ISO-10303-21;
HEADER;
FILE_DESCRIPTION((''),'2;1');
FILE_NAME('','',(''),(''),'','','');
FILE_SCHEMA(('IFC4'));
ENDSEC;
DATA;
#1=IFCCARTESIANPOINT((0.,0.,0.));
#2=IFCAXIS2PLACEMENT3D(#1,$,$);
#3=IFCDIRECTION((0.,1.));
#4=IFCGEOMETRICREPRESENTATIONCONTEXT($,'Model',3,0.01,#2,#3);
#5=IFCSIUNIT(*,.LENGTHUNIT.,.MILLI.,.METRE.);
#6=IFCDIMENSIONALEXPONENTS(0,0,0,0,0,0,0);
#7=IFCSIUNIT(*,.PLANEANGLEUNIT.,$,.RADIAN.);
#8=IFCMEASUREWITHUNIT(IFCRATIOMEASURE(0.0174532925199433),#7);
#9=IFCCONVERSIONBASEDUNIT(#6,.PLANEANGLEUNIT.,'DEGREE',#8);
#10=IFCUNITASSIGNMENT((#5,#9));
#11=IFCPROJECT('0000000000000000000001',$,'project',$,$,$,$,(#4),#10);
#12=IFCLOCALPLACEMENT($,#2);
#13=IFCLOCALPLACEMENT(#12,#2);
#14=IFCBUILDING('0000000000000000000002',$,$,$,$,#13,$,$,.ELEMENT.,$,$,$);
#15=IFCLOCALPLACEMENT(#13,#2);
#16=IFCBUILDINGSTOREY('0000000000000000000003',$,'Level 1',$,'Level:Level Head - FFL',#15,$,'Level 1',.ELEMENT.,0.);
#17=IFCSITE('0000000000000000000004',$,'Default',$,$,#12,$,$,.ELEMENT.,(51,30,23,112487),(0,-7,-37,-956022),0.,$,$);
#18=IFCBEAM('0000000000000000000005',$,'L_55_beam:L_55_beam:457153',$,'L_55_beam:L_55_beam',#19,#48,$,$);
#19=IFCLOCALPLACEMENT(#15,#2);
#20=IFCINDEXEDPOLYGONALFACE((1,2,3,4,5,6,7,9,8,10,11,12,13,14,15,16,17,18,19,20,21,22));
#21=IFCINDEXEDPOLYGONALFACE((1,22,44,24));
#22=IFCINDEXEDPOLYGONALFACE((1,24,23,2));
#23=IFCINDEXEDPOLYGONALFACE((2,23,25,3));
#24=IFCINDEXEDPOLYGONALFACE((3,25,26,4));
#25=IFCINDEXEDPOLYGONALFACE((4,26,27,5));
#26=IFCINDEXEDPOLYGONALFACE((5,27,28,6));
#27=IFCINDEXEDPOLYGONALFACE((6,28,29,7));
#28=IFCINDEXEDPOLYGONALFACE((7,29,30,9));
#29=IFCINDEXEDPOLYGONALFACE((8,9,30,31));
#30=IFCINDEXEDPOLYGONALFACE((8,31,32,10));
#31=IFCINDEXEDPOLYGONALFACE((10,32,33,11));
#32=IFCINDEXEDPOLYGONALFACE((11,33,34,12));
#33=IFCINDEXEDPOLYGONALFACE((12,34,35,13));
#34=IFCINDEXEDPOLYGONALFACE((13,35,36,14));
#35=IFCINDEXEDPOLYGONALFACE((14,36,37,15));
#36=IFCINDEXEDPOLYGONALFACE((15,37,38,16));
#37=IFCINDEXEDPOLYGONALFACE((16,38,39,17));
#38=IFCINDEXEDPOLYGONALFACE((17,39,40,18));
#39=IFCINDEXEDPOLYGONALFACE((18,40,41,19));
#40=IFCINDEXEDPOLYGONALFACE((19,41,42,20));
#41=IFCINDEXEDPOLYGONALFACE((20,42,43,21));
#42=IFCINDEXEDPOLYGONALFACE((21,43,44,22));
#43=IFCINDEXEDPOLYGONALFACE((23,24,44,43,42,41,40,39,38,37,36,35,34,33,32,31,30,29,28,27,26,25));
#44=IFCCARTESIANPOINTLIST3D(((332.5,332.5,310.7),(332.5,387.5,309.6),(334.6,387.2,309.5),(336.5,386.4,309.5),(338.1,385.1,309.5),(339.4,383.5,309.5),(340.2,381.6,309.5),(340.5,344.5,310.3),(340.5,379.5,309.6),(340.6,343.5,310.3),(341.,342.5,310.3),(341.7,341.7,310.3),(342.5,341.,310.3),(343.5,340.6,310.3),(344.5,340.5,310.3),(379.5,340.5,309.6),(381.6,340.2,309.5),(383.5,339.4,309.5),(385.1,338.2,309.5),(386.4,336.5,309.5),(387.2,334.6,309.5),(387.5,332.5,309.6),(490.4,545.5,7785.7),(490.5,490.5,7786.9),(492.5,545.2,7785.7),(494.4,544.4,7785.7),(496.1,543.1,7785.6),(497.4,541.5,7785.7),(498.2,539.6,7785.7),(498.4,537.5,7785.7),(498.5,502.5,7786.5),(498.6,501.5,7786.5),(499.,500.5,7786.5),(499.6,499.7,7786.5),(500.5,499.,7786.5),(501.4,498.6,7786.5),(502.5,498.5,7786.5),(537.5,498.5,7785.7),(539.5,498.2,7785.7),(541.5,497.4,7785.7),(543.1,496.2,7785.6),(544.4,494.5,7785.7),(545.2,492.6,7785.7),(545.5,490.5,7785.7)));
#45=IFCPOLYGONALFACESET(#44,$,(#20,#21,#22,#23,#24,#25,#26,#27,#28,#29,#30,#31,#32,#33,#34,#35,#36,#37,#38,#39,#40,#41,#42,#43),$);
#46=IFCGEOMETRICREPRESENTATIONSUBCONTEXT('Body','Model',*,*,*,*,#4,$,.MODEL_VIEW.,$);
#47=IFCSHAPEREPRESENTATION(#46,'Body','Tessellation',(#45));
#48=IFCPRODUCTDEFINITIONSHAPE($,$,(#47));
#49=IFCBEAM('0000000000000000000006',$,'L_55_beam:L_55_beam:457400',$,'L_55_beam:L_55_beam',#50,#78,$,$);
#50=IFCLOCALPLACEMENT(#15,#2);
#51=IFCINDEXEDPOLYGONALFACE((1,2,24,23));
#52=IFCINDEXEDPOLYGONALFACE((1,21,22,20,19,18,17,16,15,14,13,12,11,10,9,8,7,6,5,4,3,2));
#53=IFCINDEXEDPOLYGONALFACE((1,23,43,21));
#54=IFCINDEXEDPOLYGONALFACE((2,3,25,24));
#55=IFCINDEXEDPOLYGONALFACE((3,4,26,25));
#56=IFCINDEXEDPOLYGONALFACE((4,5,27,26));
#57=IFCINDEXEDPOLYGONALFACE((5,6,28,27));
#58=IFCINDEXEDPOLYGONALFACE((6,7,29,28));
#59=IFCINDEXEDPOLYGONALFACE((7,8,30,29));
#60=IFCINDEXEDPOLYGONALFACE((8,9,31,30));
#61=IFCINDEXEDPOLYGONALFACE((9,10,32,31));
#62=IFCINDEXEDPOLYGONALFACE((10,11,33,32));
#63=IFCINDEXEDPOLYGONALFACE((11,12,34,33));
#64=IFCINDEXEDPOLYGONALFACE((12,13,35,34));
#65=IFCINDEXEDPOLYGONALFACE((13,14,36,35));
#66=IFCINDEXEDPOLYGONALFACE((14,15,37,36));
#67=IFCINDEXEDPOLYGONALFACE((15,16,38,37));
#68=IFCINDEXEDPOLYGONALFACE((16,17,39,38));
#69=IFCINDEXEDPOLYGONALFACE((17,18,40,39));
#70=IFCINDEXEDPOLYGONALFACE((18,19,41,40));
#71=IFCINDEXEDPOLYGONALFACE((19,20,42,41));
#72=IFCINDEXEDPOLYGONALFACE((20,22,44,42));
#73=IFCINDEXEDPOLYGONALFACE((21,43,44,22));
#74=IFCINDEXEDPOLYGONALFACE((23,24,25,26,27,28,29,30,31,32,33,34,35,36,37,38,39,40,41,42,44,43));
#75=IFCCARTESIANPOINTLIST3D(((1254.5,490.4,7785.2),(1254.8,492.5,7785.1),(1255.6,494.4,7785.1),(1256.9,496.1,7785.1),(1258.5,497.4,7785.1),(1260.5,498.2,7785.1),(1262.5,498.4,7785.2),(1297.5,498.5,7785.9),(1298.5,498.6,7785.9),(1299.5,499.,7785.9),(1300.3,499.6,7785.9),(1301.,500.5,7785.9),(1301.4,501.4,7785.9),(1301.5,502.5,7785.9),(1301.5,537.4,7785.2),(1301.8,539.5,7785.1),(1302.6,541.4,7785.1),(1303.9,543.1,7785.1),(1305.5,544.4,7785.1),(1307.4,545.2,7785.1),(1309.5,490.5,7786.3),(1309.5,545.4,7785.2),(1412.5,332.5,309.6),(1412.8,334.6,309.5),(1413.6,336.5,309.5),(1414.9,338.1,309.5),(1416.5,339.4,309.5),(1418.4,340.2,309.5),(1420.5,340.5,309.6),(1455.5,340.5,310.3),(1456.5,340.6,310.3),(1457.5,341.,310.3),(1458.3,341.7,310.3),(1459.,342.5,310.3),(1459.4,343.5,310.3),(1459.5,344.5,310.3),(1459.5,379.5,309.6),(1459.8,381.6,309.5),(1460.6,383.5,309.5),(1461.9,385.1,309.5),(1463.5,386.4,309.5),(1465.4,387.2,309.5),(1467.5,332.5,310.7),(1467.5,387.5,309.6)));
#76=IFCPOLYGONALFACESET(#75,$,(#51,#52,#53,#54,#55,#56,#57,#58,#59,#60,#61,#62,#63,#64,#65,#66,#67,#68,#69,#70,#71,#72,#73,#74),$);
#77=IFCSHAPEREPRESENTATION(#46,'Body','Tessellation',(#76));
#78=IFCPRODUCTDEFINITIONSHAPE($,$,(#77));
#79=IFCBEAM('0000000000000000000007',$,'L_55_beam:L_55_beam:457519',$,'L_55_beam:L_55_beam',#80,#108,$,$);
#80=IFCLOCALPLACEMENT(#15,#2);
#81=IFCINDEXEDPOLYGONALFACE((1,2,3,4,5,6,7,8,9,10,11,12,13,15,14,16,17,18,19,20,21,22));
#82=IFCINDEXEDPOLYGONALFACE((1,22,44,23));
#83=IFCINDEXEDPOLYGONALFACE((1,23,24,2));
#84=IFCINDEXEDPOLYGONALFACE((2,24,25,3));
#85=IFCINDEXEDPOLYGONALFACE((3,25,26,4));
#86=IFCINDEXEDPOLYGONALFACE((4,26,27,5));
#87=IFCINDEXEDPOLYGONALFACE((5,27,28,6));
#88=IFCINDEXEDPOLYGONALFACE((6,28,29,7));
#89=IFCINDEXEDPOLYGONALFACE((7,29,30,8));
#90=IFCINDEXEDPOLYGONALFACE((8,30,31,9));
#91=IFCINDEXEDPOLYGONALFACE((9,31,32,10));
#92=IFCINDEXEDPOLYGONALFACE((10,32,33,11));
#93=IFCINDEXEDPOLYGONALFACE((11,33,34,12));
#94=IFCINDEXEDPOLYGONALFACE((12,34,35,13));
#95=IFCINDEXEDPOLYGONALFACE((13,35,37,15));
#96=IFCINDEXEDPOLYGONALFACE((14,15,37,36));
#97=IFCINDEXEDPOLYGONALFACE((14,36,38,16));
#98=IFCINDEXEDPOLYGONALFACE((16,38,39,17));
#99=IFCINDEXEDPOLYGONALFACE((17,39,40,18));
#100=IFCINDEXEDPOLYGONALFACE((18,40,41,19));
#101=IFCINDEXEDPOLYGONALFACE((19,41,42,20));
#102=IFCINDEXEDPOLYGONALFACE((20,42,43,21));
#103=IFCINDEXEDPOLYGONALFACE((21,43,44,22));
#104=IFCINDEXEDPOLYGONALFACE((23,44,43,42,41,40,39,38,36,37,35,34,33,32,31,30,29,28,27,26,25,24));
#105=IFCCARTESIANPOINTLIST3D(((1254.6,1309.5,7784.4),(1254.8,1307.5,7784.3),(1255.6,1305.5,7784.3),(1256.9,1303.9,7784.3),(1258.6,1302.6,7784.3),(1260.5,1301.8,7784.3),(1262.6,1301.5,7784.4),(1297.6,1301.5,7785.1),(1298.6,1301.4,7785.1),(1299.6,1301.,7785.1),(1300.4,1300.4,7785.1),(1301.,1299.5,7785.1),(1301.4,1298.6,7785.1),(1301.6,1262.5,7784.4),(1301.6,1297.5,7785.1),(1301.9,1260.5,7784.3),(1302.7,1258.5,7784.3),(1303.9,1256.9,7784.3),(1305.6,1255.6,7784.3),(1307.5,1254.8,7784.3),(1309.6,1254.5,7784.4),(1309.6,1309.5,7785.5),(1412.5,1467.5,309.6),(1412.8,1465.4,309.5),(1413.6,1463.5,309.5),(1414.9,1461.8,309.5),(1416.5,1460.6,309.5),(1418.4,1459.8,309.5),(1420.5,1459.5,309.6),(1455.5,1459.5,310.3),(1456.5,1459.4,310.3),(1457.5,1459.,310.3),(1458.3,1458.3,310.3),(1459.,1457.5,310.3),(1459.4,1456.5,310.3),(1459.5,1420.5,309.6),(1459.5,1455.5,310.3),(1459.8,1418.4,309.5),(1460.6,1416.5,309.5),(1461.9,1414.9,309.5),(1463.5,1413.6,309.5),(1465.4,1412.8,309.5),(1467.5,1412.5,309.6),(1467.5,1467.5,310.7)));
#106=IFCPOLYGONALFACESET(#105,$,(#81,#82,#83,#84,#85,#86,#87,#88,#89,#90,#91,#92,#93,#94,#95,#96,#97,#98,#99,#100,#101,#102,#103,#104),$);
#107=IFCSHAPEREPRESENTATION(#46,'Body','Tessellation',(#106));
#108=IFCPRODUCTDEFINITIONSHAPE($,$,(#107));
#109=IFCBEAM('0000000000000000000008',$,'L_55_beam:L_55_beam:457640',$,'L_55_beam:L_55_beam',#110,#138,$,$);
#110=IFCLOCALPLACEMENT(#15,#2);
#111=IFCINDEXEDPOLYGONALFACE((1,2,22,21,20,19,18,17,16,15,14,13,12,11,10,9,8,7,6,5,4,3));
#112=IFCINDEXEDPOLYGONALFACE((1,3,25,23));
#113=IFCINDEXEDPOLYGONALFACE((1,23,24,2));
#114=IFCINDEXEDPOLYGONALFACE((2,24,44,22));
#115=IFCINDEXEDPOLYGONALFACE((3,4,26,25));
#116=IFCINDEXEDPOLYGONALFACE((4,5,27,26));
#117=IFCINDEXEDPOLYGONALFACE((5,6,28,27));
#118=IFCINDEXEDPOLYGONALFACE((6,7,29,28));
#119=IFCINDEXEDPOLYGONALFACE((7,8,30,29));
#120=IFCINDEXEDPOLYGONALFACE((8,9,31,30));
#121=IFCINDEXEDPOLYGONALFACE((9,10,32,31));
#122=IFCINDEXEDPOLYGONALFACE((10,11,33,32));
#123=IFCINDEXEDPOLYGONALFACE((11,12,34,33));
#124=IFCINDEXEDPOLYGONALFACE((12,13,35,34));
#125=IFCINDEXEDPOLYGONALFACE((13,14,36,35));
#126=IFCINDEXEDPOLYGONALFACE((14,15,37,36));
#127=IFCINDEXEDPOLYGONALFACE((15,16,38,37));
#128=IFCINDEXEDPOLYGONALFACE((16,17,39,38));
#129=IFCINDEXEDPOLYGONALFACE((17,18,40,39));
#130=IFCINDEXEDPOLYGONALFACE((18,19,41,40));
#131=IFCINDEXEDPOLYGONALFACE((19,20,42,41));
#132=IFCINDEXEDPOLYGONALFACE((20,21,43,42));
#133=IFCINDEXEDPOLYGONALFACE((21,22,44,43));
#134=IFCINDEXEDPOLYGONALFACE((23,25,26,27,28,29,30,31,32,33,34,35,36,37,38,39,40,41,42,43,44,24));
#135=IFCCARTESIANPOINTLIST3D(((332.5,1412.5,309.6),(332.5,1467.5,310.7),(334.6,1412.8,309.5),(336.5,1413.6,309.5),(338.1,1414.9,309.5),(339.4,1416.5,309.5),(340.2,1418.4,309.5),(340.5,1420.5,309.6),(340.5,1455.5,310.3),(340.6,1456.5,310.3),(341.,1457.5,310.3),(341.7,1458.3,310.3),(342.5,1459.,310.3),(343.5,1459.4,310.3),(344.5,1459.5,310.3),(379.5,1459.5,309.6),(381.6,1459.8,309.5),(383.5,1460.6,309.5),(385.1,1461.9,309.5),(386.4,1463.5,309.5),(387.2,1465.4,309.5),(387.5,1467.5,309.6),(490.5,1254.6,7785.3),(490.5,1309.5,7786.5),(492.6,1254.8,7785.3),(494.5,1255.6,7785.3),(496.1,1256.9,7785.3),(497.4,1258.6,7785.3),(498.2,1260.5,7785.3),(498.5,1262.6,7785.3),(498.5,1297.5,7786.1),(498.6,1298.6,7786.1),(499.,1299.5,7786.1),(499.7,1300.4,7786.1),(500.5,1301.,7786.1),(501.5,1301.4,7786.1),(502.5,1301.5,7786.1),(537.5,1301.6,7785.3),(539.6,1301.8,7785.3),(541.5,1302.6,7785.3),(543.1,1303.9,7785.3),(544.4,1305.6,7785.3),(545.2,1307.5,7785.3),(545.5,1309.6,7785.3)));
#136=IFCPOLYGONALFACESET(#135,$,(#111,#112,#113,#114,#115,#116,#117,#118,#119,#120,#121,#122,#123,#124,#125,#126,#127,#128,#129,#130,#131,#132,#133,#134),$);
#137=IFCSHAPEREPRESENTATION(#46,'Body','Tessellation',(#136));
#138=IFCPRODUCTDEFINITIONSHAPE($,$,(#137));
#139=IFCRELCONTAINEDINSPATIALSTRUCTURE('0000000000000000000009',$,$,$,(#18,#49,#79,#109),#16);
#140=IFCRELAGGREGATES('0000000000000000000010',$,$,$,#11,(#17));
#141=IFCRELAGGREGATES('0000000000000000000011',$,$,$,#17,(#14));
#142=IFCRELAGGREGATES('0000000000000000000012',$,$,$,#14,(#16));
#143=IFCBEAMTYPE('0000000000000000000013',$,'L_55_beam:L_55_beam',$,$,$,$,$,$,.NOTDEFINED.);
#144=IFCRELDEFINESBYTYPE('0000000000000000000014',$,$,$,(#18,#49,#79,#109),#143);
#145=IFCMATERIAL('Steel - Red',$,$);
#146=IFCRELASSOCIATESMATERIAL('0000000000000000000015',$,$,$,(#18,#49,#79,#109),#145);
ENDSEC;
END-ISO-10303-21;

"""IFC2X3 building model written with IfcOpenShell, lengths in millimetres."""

from ifc_helpers import new_model, entity, si_unit, converted_unit, direction, frame, frame_2d, origin, place, context, subcontext, project, spatial, polyline, circle_curve, parameter, trimmed, segment, composite_curve, outline, extrude, material, type_object, element, save


model = new_model("IFC2X3")

# Units and contexts
model_context = context("Model", 3, precision=0.01, world=origin(), true_north=direction((0.0, 1.0)))
body_context = subcontext(model_context, "Body", "Model", "MODEL_VIEW")
ifc_project = project(units=[si_unit("LENGTHUNIT", "METRE", prefix="MILLI"), converted_unit("PLANEANGLEUNIT", "DEGREE", entity("IfcRatioMeasure", 0.0174532925199433), si_unit("PLANEANGLEUNIT", "RADIAN"), dimensions=[0, 0, 0, 0, 0, 0, 0])], contexts=[model_context])

# Site, building, storey
site_placement = place(None, origin())
site = spatial("IfcSite", under=ifc_project, at=site_placement, Name="Default", CompositionType="ELEMENT", RefLatitude=(51, 30, 23, 112487), RefLongitude=(0, -7, -37, -956022), RefElevation=0.0)
building_placement = place(site_placement, origin())
building = spatial("IfcBuilding", under=site, at=building_placement, CompositionType="ELEMENT")
storey_placement = place(building_placement, origin())
storey = spatial("IfcBuildingStorey", under=building, at=storey_placement, Name="Level 1", ObjectType="Level:Level Head - FFL", LongName="Level 1", CompositionType="ELEMENT", Elevation=0.0)

# Beams
ifc_material_1 = material(Name="Steel - Red")
beam_type_1 = type_object("IfcBeamType", Name="L_55_beam:L_55_beam", PredefinedType="NOTDEFINED")
beam_1_placement = place(storey_placement, frame((490.5, 490.5, 7786.9), z_axis=(0.999777, -0.000446, -0.021115), x_axis=(-0.02112, -0.021125, -0.999554)))
element("IfcBeam", 1, at=beam_1_placement, inside=storey, type_object=beam_type_1, material=ifc_material_1, Name="L_55_beam:L_55_beam:457153", ObjectType="L_55_beam:L_55_beam", context=body_context, shape_type="SweptSolid", body=[
    extrude(outline(composite_curve([segment(polyline([(-6.6, 10.6), (28.4, 10.6)]), True, "CONTINUOUS"), segment(trimmed(circle_curve(frame_2d((28.4, 18.6), x_axis=(0.0, -1.0)), 8.0), [parameter(0.0)], [parameter(90.0)], True, "PARAMETER"), True, "CONTINUOUS"), segment(polyline([(36.4, 18.6), (-18.6, 18.6)]), True, "CONTINUOUS"), segment(polyline([(-18.6, 18.6), (-18.6, -36.4)]), True, "CONTINUOUS"), segment(trimmed(circle_curve(frame_2d((-18.6, -28.4), x_axis=(0.0, -1.0)), 8.0), [parameter(0.0)], [parameter(90.0)], True, "PARAMETER"), True, "CONTINUOUS"), segment(polyline([(-10.6, -28.4), (-10.6, 6.6)]), True, "CONTINUOUS"), segment(trimmed(circle_curve(frame_2d((-6.6, 6.6), x_axis=(-1.0, 0.0)), 4.0), [parameter(270.0)], [parameter(0.0)], True, "PARAMETER"), False, "CONTINUOUS")], self_intersect=False)), frame((0.0, 18.6, 18.6), z_axis=(1.0, 0.0, 0.0), x_axis=(0.0, 0.000332, 1.0)), (0.0, 0.0, 1.0), 7479.5),
])
beam_2_placement = place(storey_placement, frame((1309.5, 490.5, 7786.3), z_axis=(0.999777, 0.000446, 0.02112), x_axis=(0.021125, -0.02112, -0.999554)))
element("IfcBeam", 2, at=beam_2_placement, inside=storey, type_object=beam_type_1, material=ifc_material_1, Name="L_55_beam:L_55_beam:457400", ObjectType="L_55_beam:L_55_beam", context=body_context, shape_type="SweptSolid", body=[
    extrude(outline(composite_curve([segment(polyline([(-36.4, -18.6), (18.6, -18.6)]), True, "CONTINUOUS"), segment(polyline([(18.6, -18.6), (18.6, 36.4)]), True, "CONTINUOUS"), segment(trimmed(circle_curve(frame_2d((18.6, 28.4), x_axis=(0.0, 1.0)), 8.0), [parameter(0.0)], [parameter(90.0)], True, "PARAMETER"), True, "CONTINUOUS"), segment(polyline([(10.6, 28.4), (10.6, -6.6)]), True, "CONTINUOUS"), segment(trimmed(circle_curve(frame_2d((6.6, -6.6), x_axis=(1.0, 0.0)), 4.0), [parameter(270.0)], [parameter(0.0)], True, "PARAMETER"), False, "CONTINUOUS"), segment(polyline([(6.6, -10.6), (-28.4, -10.6)]), True, "CONTINUOUS"), segment(trimmed(circle_curve(frame_2d((-28.4, -18.6), x_axis=(0.0, 1.0)), 8.0), [parameter(0.0)], [parameter(90.0)], True, "PARAMETER"), True, "CONTINUOUS")], self_intersect=False)), frame((0.0, 18.6, -18.6), z_axis=(1.0, 0.0, 0.0), x_axis=(0.0, -1.0, -0.000112)), (0.0, 0.0, 1.0), 7478.9),
])
beam_3_placement = place(storey_placement, frame((1309.6, 1309.5, 7785.5), z_axis=(0.999777, -0.000446, 0.021115), x_axis=(0.02112, 0.021125, -0.999554)))
element("IfcBeam", 3, at=beam_3_placement, inside=storey, type_object=beam_type_1, material=ifc_material_1, Name="L_55_beam:L_55_beam:457519", ObjectType="L_55_beam:L_55_beam", context=body_context, shape_type="SweptSolid", body=[
    extrude(outline(composite_curve([segment(polyline([(-36.4, -18.6), (18.6, -18.6)]), True, "CONTINUOUS"), segment(polyline([(18.6, -18.6), (18.6, 36.4)]), True, "CONTINUOUS"), segment(trimmed(circle_curve(frame_2d((18.6, 28.4), x_axis=(0.0, 1.0)), 8.0), [parameter(0.0)], [parameter(90.0)], True, "PARAMETER"), True, "CONTINUOUS"), segment(polyline([(10.6, 28.4), (10.6, -6.6)]), True, "CONTINUOUS"), segment(trimmed(circle_curve(frame_2d((6.6, -6.6), x_axis=(1.0, 0.0)), 4.0), [parameter(270.0)], [parameter(0.0)], True, "PARAMETER"), False, "CONTINUOUS"), segment(polyline([(6.6, -10.6), (-28.4, -10.6)]), True, "CONTINUOUS"), segment(trimmed(circle_curve(frame_2d((-28.4, -18.6), x_axis=(0.0, 1.0)), 8.0), [parameter(0.0)], [parameter(90.0)], True, "PARAMETER"), True, "CONTINUOUS")], self_intersect=False)), frame((0.0, -18.6, -18.6), z_axis=(1.0, 0.0, 0.0), x_axis=(0.0, 0.000332, 1.0)), (0.0, 0.0, 1.0), 7478.1),
])
beam_4_placement = place(storey_placement, frame((490.5, 1309.5, 7786.5), z_axis=(0.999777, 0.000446, -0.02112), x_axis=(-0.021125, 0.02112, -0.999554)))
element("IfcBeam", 4, at=beam_4_placement, inside=storey, type_object=beam_type_1, material=ifc_material_1, Name="L_55_beam:L_55_beam:457640", ObjectType="L_55_beam:L_55_beam", context=body_context, shape_type="SweptSolid", body=[
    extrude(outline(composite_curve([segment(polyline([(-18.6, -18.6), (36.4, -18.6)]), True, "CONTINUOUS"), segment(trimmed(circle_curve(frame_2d((28.4, -18.6), x_axis=(1.0, 0.0)), 8.0), [parameter(0.0)], [parameter(90.0)], True, "PARAMETER"), True, "CONTINUOUS"), segment(polyline([(28.4, -10.6), (-6.6, -10.6)]), True, "CONTINUOUS"), segment(trimmed(circle_curve(frame_2d((-6.6, -6.6), x_axis=(0.0, -1.0)), 4.0), [parameter(270.0)], [parameter(0.0)], True, "PARAMETER"), False, "CONTINUOUS"), segment(polyline([(-10.6, -6.6), (-10.6, 28.4)]), True, "CONTINUOUS"), segment(trimmed(circle_curve(frame_2d((-18.6, 28.4), x_axis=(1.0, 0.0)), 8.0), [parameter(0.0)], [parameter(90.0)], True, "PARAMETER"), True, "CONTINUOUS"), segment(polyline([(-18.6, 36.4), (-18.6, -18.6)]), True, "CONTINUOUS")], self_intersect=False)), frame((0.0, -18.6, 18.6), z_axis=(1.0, 0.0, 0.0), x_axis=(0.0, -0.000112, 1.0)), (0.0, 0.0, 1.0), 7479.1),
])

save(model, "model.ifc")
